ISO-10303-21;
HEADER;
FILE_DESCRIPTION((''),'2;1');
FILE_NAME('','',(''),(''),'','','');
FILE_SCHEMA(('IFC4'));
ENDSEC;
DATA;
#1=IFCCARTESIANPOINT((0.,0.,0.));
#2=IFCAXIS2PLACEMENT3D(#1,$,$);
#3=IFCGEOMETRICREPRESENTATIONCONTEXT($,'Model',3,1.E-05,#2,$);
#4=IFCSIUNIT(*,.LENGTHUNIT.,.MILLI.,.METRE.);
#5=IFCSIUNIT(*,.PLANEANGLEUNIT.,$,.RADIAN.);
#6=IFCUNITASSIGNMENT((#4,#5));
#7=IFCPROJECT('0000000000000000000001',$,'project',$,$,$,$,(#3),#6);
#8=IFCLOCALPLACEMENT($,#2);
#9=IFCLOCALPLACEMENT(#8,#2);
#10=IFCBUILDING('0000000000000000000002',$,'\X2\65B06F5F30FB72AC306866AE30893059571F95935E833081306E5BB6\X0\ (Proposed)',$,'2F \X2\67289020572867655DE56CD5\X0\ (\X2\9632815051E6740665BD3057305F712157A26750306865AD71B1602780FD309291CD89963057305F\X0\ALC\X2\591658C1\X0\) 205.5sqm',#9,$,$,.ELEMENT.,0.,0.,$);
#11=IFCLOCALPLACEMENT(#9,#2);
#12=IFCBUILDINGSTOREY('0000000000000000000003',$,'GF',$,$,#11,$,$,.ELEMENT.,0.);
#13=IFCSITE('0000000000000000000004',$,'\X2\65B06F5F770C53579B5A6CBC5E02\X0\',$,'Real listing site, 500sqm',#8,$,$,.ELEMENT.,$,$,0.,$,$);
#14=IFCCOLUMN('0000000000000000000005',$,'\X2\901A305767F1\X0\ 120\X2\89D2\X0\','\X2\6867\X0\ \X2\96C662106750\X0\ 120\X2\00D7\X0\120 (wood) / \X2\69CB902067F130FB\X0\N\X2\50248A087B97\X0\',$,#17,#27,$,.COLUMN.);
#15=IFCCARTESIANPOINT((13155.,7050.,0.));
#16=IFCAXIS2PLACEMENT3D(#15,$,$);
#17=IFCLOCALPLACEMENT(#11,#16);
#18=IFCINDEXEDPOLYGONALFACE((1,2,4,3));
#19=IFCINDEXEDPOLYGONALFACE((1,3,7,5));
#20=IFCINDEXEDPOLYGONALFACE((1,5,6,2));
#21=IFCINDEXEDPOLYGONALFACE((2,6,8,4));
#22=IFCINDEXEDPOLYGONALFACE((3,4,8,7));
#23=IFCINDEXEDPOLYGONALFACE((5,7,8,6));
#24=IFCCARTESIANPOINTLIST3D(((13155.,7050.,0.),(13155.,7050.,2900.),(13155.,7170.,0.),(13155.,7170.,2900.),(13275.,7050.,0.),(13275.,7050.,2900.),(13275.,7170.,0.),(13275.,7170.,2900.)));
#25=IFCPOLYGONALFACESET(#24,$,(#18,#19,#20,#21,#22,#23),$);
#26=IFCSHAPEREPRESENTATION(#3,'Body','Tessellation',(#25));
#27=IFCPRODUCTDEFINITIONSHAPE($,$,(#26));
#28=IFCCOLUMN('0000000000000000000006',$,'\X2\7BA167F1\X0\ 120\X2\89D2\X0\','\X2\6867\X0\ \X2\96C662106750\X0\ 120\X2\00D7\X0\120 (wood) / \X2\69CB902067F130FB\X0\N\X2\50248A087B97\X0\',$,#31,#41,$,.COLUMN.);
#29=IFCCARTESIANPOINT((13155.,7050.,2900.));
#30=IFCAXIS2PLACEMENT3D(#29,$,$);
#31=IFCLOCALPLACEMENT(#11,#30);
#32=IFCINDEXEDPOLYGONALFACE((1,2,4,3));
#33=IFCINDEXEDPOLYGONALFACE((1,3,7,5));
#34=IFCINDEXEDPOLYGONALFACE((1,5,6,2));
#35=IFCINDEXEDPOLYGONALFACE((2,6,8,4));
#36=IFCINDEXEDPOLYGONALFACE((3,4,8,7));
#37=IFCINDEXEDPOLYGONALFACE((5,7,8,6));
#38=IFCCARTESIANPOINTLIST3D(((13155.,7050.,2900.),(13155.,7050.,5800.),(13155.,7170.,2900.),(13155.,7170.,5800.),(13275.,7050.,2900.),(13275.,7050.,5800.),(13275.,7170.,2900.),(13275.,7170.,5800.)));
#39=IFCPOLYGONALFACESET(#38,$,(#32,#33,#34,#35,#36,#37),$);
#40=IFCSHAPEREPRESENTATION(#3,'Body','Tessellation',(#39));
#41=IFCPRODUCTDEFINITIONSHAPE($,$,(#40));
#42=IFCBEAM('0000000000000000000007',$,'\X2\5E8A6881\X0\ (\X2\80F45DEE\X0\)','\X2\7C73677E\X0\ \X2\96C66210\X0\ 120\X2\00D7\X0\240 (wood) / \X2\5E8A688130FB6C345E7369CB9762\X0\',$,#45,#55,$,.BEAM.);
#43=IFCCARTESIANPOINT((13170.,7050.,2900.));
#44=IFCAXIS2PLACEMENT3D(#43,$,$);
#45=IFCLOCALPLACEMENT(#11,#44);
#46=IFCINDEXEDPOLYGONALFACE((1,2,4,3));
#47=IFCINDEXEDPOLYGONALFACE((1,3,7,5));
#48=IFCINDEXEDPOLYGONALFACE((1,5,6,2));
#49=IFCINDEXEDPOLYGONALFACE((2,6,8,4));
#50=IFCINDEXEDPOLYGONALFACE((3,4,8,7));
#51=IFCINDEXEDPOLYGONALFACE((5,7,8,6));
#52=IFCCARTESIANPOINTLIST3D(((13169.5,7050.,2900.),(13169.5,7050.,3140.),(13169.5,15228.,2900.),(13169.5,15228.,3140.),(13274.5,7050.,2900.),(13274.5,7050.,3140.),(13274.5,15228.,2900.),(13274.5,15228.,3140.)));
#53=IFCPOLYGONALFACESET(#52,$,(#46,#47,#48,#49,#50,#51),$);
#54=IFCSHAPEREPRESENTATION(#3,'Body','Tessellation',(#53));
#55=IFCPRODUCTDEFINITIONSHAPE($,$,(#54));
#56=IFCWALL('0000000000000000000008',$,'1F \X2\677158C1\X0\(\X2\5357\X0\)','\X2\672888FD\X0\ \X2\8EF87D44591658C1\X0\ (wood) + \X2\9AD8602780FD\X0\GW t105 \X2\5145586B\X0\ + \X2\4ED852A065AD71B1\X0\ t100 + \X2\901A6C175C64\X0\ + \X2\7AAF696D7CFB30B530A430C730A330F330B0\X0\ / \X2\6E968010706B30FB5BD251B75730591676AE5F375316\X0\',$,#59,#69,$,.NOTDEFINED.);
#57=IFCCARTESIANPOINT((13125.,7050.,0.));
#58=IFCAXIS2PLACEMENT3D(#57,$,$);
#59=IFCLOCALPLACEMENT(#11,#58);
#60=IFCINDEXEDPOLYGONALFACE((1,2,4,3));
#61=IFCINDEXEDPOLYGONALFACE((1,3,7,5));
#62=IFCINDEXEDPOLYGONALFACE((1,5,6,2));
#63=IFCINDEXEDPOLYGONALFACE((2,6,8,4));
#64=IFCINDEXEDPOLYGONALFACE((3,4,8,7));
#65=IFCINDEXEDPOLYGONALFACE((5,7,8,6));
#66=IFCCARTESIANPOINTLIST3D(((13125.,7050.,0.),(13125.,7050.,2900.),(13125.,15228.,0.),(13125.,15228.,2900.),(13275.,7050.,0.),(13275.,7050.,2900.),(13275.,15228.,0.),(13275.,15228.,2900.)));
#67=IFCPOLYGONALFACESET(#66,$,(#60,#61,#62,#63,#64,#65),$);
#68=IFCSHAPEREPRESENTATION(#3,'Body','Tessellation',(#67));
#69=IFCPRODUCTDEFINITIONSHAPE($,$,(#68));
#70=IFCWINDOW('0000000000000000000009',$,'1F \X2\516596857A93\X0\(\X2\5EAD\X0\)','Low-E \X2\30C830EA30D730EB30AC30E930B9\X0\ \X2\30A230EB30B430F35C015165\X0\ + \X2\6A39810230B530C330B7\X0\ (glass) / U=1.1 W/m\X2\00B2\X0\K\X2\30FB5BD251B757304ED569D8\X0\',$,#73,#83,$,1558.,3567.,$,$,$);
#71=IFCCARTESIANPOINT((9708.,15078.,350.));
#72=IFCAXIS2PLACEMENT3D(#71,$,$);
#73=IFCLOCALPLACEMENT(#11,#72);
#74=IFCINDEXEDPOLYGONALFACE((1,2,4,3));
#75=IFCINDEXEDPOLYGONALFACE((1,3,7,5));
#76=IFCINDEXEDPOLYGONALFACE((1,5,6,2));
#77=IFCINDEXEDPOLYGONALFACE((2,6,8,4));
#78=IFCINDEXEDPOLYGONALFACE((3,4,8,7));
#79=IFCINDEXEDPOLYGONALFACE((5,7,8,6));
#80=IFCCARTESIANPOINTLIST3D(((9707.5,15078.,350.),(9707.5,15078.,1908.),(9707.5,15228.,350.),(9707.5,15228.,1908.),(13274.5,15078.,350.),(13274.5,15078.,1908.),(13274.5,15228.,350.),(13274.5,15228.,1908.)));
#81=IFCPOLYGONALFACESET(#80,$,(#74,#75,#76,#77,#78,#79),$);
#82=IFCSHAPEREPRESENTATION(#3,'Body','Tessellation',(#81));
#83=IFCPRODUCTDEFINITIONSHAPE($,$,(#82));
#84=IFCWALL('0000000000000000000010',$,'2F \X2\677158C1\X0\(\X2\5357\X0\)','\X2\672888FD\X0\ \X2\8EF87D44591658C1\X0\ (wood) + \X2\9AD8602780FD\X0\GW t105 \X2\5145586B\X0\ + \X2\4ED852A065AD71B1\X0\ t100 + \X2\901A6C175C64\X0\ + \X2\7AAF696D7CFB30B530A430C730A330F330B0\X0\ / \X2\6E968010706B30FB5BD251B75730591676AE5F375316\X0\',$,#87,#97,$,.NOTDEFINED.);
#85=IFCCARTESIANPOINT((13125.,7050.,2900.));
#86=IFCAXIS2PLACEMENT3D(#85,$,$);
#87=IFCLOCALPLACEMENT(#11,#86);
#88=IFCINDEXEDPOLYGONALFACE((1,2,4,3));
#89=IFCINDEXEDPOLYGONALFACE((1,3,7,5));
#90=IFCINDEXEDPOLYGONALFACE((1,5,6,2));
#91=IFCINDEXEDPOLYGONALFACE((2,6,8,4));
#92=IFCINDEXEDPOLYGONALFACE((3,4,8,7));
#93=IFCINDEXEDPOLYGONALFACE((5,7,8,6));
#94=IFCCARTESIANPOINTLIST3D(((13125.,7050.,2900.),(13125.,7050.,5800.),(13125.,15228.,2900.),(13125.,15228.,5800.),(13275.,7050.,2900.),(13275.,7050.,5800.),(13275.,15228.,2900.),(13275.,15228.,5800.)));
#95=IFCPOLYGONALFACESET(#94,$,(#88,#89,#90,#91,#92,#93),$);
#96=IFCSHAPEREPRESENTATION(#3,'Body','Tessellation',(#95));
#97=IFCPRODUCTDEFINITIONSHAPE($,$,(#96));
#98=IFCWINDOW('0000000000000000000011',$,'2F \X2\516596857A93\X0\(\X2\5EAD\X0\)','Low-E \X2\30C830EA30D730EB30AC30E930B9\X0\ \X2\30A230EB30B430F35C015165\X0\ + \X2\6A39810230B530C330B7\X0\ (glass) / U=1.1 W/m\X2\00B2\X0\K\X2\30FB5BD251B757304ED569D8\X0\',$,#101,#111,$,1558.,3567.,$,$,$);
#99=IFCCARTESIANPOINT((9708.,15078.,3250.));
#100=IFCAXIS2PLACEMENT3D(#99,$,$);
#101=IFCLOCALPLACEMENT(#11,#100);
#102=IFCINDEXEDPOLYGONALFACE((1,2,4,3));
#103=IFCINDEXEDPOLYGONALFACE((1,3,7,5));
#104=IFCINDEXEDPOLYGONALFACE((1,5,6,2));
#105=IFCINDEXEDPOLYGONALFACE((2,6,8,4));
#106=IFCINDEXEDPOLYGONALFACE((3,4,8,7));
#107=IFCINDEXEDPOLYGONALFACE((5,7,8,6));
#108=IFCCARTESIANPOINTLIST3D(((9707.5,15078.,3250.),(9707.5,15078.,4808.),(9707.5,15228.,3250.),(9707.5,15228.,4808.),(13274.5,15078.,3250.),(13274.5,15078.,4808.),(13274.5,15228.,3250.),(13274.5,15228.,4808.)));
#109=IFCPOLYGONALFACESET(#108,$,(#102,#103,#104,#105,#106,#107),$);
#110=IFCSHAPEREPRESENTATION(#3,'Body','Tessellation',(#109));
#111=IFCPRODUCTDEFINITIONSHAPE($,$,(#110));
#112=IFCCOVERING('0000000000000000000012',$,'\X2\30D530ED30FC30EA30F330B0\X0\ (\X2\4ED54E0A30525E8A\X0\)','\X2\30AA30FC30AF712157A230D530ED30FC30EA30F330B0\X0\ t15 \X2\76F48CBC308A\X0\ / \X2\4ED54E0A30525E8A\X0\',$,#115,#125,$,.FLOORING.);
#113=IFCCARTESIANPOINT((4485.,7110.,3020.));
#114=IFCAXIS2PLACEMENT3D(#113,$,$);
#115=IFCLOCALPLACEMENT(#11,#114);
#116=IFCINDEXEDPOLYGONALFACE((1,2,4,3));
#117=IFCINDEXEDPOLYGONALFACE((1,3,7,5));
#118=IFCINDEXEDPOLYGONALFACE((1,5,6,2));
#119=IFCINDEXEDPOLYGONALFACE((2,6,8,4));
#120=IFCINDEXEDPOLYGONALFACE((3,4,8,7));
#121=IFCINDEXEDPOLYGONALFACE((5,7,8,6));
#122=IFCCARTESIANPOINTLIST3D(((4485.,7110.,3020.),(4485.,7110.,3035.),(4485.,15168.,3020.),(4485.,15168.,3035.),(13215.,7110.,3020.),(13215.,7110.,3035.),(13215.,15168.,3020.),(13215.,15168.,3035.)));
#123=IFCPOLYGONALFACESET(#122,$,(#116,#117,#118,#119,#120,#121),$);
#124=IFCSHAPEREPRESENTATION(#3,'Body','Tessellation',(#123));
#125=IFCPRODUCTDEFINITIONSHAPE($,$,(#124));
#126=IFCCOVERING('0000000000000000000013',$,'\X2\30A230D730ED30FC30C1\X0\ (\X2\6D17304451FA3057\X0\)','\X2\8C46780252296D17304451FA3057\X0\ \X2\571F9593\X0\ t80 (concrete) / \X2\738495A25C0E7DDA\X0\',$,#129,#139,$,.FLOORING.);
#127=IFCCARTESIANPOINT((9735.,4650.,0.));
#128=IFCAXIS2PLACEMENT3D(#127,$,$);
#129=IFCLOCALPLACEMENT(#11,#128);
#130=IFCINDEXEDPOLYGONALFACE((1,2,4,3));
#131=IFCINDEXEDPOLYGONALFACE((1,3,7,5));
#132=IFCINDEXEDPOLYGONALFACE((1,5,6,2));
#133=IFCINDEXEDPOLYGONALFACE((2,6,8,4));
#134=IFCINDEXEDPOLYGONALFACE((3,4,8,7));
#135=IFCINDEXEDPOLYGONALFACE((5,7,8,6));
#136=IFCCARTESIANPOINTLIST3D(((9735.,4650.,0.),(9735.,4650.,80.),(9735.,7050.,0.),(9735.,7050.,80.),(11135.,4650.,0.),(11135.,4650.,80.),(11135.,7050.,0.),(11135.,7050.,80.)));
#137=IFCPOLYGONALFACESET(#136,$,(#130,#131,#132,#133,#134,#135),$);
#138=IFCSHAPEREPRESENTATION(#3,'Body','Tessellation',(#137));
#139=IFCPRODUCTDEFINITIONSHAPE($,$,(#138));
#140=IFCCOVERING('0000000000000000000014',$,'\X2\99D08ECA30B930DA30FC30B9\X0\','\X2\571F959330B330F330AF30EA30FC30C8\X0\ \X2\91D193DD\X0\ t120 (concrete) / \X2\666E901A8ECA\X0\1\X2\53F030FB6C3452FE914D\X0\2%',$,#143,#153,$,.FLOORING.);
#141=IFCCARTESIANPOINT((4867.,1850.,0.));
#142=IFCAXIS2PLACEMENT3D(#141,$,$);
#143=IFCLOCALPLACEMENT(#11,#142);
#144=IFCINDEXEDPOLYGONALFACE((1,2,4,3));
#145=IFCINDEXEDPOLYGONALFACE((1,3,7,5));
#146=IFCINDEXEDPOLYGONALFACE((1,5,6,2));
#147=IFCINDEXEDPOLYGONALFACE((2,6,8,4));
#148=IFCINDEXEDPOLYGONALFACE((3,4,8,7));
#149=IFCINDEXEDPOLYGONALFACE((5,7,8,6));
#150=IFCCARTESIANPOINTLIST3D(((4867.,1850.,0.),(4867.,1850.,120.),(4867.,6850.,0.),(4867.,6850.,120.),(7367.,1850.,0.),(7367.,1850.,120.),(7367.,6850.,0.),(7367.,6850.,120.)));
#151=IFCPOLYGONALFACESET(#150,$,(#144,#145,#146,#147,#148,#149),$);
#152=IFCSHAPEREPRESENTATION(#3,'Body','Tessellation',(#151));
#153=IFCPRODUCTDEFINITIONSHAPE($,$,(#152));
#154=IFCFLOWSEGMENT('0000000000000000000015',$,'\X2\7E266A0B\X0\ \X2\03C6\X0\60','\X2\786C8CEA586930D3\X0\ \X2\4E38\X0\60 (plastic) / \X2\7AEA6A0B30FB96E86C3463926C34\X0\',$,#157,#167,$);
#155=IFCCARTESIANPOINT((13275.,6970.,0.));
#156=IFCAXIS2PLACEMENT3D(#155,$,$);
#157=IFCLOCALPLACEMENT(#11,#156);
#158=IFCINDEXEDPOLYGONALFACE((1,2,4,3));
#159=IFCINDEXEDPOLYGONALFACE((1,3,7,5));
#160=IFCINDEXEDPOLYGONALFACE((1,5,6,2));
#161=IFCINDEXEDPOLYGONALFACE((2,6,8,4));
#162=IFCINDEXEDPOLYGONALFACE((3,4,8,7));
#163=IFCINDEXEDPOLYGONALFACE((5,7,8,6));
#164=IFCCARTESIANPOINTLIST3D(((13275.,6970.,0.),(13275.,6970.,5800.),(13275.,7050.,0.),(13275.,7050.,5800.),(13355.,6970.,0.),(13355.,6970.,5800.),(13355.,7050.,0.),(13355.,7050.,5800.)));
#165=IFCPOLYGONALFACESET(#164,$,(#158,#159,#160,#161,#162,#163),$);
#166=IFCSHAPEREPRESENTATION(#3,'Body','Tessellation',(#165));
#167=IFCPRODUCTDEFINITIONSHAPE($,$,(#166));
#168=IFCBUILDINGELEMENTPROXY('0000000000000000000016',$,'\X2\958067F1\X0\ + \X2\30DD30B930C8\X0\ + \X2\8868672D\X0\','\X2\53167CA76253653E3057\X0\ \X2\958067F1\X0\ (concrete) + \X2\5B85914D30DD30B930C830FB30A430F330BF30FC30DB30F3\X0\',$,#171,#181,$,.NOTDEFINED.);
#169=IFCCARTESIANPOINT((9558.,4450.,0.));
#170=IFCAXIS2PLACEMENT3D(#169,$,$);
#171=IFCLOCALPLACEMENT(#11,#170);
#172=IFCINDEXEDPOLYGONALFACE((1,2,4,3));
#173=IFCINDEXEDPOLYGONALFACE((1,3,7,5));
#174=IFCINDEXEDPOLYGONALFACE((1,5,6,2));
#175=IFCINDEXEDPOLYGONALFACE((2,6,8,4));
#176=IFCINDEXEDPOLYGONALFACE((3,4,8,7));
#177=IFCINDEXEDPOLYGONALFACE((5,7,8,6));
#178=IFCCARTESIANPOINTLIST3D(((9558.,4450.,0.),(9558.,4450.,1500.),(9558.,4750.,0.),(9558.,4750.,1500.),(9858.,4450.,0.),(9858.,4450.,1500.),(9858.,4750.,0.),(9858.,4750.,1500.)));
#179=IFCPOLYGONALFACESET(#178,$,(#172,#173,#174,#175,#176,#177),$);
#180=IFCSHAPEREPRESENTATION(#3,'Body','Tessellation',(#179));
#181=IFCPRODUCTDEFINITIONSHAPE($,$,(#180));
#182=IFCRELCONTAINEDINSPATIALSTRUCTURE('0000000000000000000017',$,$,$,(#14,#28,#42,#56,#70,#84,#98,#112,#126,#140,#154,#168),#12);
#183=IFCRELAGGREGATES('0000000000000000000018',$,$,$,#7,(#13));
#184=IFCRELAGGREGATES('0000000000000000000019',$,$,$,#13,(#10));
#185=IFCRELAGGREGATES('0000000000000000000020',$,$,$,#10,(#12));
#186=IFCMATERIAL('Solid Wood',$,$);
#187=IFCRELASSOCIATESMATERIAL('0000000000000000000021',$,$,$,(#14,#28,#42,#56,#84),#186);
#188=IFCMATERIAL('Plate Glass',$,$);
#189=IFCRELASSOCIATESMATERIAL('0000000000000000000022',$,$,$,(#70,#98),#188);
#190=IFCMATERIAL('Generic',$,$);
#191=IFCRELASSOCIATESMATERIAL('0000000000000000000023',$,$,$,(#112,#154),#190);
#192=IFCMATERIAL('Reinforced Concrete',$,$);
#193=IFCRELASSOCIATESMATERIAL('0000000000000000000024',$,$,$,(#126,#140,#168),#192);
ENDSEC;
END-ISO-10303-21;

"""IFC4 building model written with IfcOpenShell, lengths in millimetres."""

from ifc_helpers import new_model, si_unit, frame, frame_2d, origin, place, context, project, spatial, rectangle, extrude, material, element, fill, save


model = new_model("IFC4")

# Units and contexts
model_context = context("Model", 3, precision=1e-05, world=origin())
ifc_project = project(units=[si_unit("LENGTHUNIT", "METRE", prefix="MILLI"), si_unit("PLANEANGLEUNIT", "RADIAN")], contexts=[model_context])

# Site, building, storey
site_placement = place(None, origin())
site = spatial("IfcSite", under=ifc_project, at=site_placement, Name="新潟県南魚沼市", ObjectType="Real listing site, 500sqm", CompositionType="ELEMENT", RefElevation=0.0)
building_placement = place(site_placement, origin())
building = spatial("IfcBuilding", under=site, at=building_placement, Name="新潟・犬と暮らす土間広めの家 (Proposed)", ObjectType="2F 木造在来工法 (防腐処理施した無垢材と断熱性能を重視したALC外壁) 205.5sqm", CompositionType="ELEMENT", ElevationOfRefHeight=0.0, ElevationOfTerrain=0.0)
storey_placement = place(building_placement, origin())
storey = spatial("IfcBuildingStorey", under=building, at=storey_placement, Name="GF", CompositionType="ELEMENT", Elevation=0.0)

# Columns
ifc_material_1 = material(Name="Solid Wood")
column_1_placement = place(storey_placement, frame((13155.0, 7050.0, 0.0)))
element("IfcColumn", 1, at=column_1_placement, inside=storey, material=ifc_material_1, Name="通し柱 120角", Description="桧 集成材 120×120 (wood) / 構造柱・N値計算", PredefinedType="COLUMN", context=model_context, shape_type="SweptSolid", body=[
    extrude(rectangle(XDim=120.0, YDim=120.0, at=frame_2d((60.0, 60.0))), frame((13155.0, 7050.0, 0.0)), (0.0, 0.0, 1.0), 2900.0),
])
column_2_placement = place(storey_placement, frame((13155.0, 7050.0, 2900.0)))
element("IfcColumn", 2, at=column_2_placement, inside=storey, material=ifc_material_1, Name="管柱 120角", Description="桧 集成材 120×120 (wood) / 構造柱・N値計算", PredefinedType="COLUMN", context=model_context, shape_type="SweptSolid", body=[
    extrude(rectangle(XDim=120.0, YDim=120.0, at=frame_2d((60.0, 60.0))), frame((13155.0, 7050.0, 2900.0)), (0.0, 0.0, 1.0), 2900.0),
])

# Beam
beam_1_placement = place(storey_placement, frame((13170.0, 7050.0, 2900.0)))
element("IfcBeam", 3, at=beam_1_placement, inside=storey, material=ifc_material_1, Name="床梁 (胴差)", Description="米松 集成 120×240 (wood) / 床梁・水平構面", PredefinedType="BEAM", context=model_context, shape_type="SweptSolid", body=[
    extrude(rectangle(XDim=105.0, YDim=8178.0, at=frame_2d((52.0, 4089.0))), frame((13170.0, 7050.0, 2900.0)), (0.0, 0.0, 1.0), 240.0),
])

# Wall, opening, window
wall_1_placement = place(storey_placement, frame((13125.0, 7050.0, 0.0)))
wall_1 = element("IfcWall", 4, at=wall_1_placement, inside=storey, material=ifc_material_1, Name="1F 東壁(南)", Description="木製 軸組外壁 (wood) + 高性能GW t105 充填 + 付加断熱 t100 + 通気層 + 窯業系サイディング / 準耐火・寒冷地外皮強化", PredefinedType="NOTDEFINED", context=model_context, shape_type="SweptSolid", body=[
    extrude(rectangle(XDim=150.0, YDim=8178.0, at=frame_2d((75.0, 4089.0))), frame((13125.0, 7050.0, 0.0)), (0.0, 0.0, 1.0), 2900.0),
])
opening_1_placement = place(storey_placement, frame((9708.0, 15078.0, 350.0)))
opening_1 = element("IfcOpeningElement", 5, at=opening_1_placement, cuts=wall_1, PredefinedType="NOTDEFINED", context=model_context, shape_type="SweptSolid", body=[
    extrude(rectangle(XDim=3567.0, YDim=150.0, at=frame_2d((1783.0, 75.0))), frame((9708.0, 15078.0, 350.0)), (0.0, 0.0, 1.0), 1558.0),
])
ifc_material_2 = material(Name="Plate Glass")
window_1_placement = place(storey_placement, frame((9708.0, 15078.0, 350.0)))
window_1 = element("IfcWindow", 6, at=window_1_placement, inside=storey, material=ifc_material_2, Name="1F 入隅窓(庭)", Description="Low-E トリプルガラス アルゴン封入 + 樹脂サッシ (glass) / U=1.1 W/m²K・寒冷地仕様", OverallHeight=1558.0, OverallWidth=3567.0, context=model_context, shape_type="SweptSolid", body=[
    extrude(rectangle(XDim=3567.0, YDim=150.0, at=frame_2d((1783.0, 75.0))), frame((9708.0, 15078.0, 350.0)), (0.0, 0.0, 1.0), 1558.0),
])
fill(opening_1, window_1)

# Wall, opening, window
wall_2_placement = place(storey_placement, frame((13125.0, 7050.0, 2900.0)))
wall_2 = element("IfcWall", 7, at=wall_2_placement, inside=storey, material=ifc_material_1, Name="2F 東壁(南)", Description="木製 軸組外壁 (wood) + 高性能GW t105 充填 + 付加断熱 t100 + 通気層 + 窯業系サイディング / 準耐火・寒冷地外皮強化", PredefinedType="NOTDEFINED", context=model_context, shape_type="SweptSolid", body=[
    extrude(rectangle(XDim=150.0, YDim=8178.0, at=frame_2d((75.0, 4089.0))), frame((13125.0, 7050.0, 2900.0)), (0.0, 0.0, 1.0), 2900.0),
])
opening_2_placement = place(storey_placement, frame((9708.0, 15078.0, 3250.0)))
opening_2 = element("IfcOpeningElement", 8, at=opening_2_placement, cuts=wall_2, PredefinedType="NOTDEFINED", context=model_context, shape_type="SweptSolid", body=[
    extrude(rectangle(XDim=3567.0, YDim=150.0, at=frame_2d((1783.0, 75.0))), frame((9708.0, 15078.0, 3250.0)), (0.0, 0.0, 1.0), 1558.0),
])
window_2_placement = place(storey_placement, frame((9708.0, 15078.0, 3250.0)))
window_2 = element("IfcWindow", 9, at=window_2_placement, inside=storey, material=ifc_material_2, Name="2F 入隅窓(庭)", Description="Low-E トリプルガラス アルゴン封入 + 樹脂サッシ (glass) / U=1.1 W/m²K・寒冷地仕様", OverallHeight=1558.0, OverallWidth=3567.0, context=model_context, shape_type="SweptSolid", body=[
    extrude(rectangle(XDim=3567.0, YDim=150.0, at=frame_2d((1783.0, 75.0))), frame((9708.0, 15078.0, 3250.0)), (0.0, 0.0, 1.0), 1558.0),
])
fill(opening_2, window_2)

# Coverings
ifc_material_3 = material(Name="Generic")
covering_1_placement = place(storey_placement, frame((4485.0, 7110.0, 3020.0)))
element("IfcCovering", 10, at=covering_1_placement, inside=storey, material=ifc_material_3, Name="フローリング (仕上げ床)", Description="オーク無垢フローリング t15 直貼り / 仕上げ床", PredefinedType="FLOORING", context=model_context, shape_type="SweptSolid", body=[
    extrude(rectangle(XDim=8730.0, YDim=8058.0, at=frame_2d((4365.0, 4029.0))), frame((4485.0, 7110.0, 3020.0)), (0.0, 0.0, 1.0), 15.0),
])
ifc_material_4 = material(Name="Reinforced Concrete")
covering_2_placement = place(storey_placement, frame((9735.0, 4650.0, 0.0)))
element("IfcCovering", 11, at=covering_2_placement, inside=storey, material=ifc_material_4, Name="アプローチ (洗い出し)", Description="豆砂利洗い出し 土間 t80 (concrete) / 玄関導線", PredefinedType="FLOORING", context=model_context, shape_type="SweptSolid", body=[
    extrude(rectangle(XDim=1400.0, YDim=2400.0, at=frame_2d((700.0, 1200.0))), frame((9735.0, 4650.0, 0.0)), (0.0, 0.0, 1.0), 80.0),
])
covering_3_placement = place(storey_placement, frame((4867.0, 1850.0, 0.0)))
element("IfcCovering", 12, at=covering_3_placement, inside=storey, material=ifc_material_4, Name="駐車スペース", Description="土間コンクリート 金鏝 t120 (concrete) / 普通車1台・水勾配2%", PredefinedType="FLOORING", context=model_context, shape_type="SweptSolid", body=[
    extrude(rectangle(XDim=2500.0, YDim=5000.0, at=frame_2d((1250.0, 2500.0))), frame((4867.0, 1850.0, 0.0)), (0.0, 0.0, 1.0), 120.0),
])

# Flow segment
flow_segment_placement = place(storey_placement, frame((13275.0, 6970.0, 0.0)))
element("IfcFlowSegment", 13, at=flow_segment_placement, inside=storey, material=ifc_material_3, Name="縦樋 φ60", Description="硬質塩ビ 丸60 (plastic) / 竪樋・雨水排水", context=model_context, shape_type="SweptSolid", body=[
    extrude(rectangle(XDim=80.0, YDim=80.0, at=frame_2d((40.0, 40.0))), frame((13275.0, 6970.0, 0.0)), (0.0, 0.0, 1.0), 5800.0),
])

# Building element proxy
proxy_placement = place(storey_placement, frame((9558.0, 4450.0, 0.0)))
element("IfcBuildingElementProxy", 14, at=proxy_placement, inside=storey, material=ifc_material_4, Name="門柱 + ポスト + 表札", Description="化粧打放し 門柱 (concrete) + 宅配ポスト・インターホン", PredefinedType="NOTDEFINED", context=model_context, shape_type="SweptSolid", body=[
    extrude(rectangle(XDim=300.0, YDim=300.0, at=frame_2d((150.0, 150.0))), frame((9558.0, 4450.0, 0.0)), (0.0, 0.0, 1.0), 1500.0),
])

save(model, "model.ifc")
